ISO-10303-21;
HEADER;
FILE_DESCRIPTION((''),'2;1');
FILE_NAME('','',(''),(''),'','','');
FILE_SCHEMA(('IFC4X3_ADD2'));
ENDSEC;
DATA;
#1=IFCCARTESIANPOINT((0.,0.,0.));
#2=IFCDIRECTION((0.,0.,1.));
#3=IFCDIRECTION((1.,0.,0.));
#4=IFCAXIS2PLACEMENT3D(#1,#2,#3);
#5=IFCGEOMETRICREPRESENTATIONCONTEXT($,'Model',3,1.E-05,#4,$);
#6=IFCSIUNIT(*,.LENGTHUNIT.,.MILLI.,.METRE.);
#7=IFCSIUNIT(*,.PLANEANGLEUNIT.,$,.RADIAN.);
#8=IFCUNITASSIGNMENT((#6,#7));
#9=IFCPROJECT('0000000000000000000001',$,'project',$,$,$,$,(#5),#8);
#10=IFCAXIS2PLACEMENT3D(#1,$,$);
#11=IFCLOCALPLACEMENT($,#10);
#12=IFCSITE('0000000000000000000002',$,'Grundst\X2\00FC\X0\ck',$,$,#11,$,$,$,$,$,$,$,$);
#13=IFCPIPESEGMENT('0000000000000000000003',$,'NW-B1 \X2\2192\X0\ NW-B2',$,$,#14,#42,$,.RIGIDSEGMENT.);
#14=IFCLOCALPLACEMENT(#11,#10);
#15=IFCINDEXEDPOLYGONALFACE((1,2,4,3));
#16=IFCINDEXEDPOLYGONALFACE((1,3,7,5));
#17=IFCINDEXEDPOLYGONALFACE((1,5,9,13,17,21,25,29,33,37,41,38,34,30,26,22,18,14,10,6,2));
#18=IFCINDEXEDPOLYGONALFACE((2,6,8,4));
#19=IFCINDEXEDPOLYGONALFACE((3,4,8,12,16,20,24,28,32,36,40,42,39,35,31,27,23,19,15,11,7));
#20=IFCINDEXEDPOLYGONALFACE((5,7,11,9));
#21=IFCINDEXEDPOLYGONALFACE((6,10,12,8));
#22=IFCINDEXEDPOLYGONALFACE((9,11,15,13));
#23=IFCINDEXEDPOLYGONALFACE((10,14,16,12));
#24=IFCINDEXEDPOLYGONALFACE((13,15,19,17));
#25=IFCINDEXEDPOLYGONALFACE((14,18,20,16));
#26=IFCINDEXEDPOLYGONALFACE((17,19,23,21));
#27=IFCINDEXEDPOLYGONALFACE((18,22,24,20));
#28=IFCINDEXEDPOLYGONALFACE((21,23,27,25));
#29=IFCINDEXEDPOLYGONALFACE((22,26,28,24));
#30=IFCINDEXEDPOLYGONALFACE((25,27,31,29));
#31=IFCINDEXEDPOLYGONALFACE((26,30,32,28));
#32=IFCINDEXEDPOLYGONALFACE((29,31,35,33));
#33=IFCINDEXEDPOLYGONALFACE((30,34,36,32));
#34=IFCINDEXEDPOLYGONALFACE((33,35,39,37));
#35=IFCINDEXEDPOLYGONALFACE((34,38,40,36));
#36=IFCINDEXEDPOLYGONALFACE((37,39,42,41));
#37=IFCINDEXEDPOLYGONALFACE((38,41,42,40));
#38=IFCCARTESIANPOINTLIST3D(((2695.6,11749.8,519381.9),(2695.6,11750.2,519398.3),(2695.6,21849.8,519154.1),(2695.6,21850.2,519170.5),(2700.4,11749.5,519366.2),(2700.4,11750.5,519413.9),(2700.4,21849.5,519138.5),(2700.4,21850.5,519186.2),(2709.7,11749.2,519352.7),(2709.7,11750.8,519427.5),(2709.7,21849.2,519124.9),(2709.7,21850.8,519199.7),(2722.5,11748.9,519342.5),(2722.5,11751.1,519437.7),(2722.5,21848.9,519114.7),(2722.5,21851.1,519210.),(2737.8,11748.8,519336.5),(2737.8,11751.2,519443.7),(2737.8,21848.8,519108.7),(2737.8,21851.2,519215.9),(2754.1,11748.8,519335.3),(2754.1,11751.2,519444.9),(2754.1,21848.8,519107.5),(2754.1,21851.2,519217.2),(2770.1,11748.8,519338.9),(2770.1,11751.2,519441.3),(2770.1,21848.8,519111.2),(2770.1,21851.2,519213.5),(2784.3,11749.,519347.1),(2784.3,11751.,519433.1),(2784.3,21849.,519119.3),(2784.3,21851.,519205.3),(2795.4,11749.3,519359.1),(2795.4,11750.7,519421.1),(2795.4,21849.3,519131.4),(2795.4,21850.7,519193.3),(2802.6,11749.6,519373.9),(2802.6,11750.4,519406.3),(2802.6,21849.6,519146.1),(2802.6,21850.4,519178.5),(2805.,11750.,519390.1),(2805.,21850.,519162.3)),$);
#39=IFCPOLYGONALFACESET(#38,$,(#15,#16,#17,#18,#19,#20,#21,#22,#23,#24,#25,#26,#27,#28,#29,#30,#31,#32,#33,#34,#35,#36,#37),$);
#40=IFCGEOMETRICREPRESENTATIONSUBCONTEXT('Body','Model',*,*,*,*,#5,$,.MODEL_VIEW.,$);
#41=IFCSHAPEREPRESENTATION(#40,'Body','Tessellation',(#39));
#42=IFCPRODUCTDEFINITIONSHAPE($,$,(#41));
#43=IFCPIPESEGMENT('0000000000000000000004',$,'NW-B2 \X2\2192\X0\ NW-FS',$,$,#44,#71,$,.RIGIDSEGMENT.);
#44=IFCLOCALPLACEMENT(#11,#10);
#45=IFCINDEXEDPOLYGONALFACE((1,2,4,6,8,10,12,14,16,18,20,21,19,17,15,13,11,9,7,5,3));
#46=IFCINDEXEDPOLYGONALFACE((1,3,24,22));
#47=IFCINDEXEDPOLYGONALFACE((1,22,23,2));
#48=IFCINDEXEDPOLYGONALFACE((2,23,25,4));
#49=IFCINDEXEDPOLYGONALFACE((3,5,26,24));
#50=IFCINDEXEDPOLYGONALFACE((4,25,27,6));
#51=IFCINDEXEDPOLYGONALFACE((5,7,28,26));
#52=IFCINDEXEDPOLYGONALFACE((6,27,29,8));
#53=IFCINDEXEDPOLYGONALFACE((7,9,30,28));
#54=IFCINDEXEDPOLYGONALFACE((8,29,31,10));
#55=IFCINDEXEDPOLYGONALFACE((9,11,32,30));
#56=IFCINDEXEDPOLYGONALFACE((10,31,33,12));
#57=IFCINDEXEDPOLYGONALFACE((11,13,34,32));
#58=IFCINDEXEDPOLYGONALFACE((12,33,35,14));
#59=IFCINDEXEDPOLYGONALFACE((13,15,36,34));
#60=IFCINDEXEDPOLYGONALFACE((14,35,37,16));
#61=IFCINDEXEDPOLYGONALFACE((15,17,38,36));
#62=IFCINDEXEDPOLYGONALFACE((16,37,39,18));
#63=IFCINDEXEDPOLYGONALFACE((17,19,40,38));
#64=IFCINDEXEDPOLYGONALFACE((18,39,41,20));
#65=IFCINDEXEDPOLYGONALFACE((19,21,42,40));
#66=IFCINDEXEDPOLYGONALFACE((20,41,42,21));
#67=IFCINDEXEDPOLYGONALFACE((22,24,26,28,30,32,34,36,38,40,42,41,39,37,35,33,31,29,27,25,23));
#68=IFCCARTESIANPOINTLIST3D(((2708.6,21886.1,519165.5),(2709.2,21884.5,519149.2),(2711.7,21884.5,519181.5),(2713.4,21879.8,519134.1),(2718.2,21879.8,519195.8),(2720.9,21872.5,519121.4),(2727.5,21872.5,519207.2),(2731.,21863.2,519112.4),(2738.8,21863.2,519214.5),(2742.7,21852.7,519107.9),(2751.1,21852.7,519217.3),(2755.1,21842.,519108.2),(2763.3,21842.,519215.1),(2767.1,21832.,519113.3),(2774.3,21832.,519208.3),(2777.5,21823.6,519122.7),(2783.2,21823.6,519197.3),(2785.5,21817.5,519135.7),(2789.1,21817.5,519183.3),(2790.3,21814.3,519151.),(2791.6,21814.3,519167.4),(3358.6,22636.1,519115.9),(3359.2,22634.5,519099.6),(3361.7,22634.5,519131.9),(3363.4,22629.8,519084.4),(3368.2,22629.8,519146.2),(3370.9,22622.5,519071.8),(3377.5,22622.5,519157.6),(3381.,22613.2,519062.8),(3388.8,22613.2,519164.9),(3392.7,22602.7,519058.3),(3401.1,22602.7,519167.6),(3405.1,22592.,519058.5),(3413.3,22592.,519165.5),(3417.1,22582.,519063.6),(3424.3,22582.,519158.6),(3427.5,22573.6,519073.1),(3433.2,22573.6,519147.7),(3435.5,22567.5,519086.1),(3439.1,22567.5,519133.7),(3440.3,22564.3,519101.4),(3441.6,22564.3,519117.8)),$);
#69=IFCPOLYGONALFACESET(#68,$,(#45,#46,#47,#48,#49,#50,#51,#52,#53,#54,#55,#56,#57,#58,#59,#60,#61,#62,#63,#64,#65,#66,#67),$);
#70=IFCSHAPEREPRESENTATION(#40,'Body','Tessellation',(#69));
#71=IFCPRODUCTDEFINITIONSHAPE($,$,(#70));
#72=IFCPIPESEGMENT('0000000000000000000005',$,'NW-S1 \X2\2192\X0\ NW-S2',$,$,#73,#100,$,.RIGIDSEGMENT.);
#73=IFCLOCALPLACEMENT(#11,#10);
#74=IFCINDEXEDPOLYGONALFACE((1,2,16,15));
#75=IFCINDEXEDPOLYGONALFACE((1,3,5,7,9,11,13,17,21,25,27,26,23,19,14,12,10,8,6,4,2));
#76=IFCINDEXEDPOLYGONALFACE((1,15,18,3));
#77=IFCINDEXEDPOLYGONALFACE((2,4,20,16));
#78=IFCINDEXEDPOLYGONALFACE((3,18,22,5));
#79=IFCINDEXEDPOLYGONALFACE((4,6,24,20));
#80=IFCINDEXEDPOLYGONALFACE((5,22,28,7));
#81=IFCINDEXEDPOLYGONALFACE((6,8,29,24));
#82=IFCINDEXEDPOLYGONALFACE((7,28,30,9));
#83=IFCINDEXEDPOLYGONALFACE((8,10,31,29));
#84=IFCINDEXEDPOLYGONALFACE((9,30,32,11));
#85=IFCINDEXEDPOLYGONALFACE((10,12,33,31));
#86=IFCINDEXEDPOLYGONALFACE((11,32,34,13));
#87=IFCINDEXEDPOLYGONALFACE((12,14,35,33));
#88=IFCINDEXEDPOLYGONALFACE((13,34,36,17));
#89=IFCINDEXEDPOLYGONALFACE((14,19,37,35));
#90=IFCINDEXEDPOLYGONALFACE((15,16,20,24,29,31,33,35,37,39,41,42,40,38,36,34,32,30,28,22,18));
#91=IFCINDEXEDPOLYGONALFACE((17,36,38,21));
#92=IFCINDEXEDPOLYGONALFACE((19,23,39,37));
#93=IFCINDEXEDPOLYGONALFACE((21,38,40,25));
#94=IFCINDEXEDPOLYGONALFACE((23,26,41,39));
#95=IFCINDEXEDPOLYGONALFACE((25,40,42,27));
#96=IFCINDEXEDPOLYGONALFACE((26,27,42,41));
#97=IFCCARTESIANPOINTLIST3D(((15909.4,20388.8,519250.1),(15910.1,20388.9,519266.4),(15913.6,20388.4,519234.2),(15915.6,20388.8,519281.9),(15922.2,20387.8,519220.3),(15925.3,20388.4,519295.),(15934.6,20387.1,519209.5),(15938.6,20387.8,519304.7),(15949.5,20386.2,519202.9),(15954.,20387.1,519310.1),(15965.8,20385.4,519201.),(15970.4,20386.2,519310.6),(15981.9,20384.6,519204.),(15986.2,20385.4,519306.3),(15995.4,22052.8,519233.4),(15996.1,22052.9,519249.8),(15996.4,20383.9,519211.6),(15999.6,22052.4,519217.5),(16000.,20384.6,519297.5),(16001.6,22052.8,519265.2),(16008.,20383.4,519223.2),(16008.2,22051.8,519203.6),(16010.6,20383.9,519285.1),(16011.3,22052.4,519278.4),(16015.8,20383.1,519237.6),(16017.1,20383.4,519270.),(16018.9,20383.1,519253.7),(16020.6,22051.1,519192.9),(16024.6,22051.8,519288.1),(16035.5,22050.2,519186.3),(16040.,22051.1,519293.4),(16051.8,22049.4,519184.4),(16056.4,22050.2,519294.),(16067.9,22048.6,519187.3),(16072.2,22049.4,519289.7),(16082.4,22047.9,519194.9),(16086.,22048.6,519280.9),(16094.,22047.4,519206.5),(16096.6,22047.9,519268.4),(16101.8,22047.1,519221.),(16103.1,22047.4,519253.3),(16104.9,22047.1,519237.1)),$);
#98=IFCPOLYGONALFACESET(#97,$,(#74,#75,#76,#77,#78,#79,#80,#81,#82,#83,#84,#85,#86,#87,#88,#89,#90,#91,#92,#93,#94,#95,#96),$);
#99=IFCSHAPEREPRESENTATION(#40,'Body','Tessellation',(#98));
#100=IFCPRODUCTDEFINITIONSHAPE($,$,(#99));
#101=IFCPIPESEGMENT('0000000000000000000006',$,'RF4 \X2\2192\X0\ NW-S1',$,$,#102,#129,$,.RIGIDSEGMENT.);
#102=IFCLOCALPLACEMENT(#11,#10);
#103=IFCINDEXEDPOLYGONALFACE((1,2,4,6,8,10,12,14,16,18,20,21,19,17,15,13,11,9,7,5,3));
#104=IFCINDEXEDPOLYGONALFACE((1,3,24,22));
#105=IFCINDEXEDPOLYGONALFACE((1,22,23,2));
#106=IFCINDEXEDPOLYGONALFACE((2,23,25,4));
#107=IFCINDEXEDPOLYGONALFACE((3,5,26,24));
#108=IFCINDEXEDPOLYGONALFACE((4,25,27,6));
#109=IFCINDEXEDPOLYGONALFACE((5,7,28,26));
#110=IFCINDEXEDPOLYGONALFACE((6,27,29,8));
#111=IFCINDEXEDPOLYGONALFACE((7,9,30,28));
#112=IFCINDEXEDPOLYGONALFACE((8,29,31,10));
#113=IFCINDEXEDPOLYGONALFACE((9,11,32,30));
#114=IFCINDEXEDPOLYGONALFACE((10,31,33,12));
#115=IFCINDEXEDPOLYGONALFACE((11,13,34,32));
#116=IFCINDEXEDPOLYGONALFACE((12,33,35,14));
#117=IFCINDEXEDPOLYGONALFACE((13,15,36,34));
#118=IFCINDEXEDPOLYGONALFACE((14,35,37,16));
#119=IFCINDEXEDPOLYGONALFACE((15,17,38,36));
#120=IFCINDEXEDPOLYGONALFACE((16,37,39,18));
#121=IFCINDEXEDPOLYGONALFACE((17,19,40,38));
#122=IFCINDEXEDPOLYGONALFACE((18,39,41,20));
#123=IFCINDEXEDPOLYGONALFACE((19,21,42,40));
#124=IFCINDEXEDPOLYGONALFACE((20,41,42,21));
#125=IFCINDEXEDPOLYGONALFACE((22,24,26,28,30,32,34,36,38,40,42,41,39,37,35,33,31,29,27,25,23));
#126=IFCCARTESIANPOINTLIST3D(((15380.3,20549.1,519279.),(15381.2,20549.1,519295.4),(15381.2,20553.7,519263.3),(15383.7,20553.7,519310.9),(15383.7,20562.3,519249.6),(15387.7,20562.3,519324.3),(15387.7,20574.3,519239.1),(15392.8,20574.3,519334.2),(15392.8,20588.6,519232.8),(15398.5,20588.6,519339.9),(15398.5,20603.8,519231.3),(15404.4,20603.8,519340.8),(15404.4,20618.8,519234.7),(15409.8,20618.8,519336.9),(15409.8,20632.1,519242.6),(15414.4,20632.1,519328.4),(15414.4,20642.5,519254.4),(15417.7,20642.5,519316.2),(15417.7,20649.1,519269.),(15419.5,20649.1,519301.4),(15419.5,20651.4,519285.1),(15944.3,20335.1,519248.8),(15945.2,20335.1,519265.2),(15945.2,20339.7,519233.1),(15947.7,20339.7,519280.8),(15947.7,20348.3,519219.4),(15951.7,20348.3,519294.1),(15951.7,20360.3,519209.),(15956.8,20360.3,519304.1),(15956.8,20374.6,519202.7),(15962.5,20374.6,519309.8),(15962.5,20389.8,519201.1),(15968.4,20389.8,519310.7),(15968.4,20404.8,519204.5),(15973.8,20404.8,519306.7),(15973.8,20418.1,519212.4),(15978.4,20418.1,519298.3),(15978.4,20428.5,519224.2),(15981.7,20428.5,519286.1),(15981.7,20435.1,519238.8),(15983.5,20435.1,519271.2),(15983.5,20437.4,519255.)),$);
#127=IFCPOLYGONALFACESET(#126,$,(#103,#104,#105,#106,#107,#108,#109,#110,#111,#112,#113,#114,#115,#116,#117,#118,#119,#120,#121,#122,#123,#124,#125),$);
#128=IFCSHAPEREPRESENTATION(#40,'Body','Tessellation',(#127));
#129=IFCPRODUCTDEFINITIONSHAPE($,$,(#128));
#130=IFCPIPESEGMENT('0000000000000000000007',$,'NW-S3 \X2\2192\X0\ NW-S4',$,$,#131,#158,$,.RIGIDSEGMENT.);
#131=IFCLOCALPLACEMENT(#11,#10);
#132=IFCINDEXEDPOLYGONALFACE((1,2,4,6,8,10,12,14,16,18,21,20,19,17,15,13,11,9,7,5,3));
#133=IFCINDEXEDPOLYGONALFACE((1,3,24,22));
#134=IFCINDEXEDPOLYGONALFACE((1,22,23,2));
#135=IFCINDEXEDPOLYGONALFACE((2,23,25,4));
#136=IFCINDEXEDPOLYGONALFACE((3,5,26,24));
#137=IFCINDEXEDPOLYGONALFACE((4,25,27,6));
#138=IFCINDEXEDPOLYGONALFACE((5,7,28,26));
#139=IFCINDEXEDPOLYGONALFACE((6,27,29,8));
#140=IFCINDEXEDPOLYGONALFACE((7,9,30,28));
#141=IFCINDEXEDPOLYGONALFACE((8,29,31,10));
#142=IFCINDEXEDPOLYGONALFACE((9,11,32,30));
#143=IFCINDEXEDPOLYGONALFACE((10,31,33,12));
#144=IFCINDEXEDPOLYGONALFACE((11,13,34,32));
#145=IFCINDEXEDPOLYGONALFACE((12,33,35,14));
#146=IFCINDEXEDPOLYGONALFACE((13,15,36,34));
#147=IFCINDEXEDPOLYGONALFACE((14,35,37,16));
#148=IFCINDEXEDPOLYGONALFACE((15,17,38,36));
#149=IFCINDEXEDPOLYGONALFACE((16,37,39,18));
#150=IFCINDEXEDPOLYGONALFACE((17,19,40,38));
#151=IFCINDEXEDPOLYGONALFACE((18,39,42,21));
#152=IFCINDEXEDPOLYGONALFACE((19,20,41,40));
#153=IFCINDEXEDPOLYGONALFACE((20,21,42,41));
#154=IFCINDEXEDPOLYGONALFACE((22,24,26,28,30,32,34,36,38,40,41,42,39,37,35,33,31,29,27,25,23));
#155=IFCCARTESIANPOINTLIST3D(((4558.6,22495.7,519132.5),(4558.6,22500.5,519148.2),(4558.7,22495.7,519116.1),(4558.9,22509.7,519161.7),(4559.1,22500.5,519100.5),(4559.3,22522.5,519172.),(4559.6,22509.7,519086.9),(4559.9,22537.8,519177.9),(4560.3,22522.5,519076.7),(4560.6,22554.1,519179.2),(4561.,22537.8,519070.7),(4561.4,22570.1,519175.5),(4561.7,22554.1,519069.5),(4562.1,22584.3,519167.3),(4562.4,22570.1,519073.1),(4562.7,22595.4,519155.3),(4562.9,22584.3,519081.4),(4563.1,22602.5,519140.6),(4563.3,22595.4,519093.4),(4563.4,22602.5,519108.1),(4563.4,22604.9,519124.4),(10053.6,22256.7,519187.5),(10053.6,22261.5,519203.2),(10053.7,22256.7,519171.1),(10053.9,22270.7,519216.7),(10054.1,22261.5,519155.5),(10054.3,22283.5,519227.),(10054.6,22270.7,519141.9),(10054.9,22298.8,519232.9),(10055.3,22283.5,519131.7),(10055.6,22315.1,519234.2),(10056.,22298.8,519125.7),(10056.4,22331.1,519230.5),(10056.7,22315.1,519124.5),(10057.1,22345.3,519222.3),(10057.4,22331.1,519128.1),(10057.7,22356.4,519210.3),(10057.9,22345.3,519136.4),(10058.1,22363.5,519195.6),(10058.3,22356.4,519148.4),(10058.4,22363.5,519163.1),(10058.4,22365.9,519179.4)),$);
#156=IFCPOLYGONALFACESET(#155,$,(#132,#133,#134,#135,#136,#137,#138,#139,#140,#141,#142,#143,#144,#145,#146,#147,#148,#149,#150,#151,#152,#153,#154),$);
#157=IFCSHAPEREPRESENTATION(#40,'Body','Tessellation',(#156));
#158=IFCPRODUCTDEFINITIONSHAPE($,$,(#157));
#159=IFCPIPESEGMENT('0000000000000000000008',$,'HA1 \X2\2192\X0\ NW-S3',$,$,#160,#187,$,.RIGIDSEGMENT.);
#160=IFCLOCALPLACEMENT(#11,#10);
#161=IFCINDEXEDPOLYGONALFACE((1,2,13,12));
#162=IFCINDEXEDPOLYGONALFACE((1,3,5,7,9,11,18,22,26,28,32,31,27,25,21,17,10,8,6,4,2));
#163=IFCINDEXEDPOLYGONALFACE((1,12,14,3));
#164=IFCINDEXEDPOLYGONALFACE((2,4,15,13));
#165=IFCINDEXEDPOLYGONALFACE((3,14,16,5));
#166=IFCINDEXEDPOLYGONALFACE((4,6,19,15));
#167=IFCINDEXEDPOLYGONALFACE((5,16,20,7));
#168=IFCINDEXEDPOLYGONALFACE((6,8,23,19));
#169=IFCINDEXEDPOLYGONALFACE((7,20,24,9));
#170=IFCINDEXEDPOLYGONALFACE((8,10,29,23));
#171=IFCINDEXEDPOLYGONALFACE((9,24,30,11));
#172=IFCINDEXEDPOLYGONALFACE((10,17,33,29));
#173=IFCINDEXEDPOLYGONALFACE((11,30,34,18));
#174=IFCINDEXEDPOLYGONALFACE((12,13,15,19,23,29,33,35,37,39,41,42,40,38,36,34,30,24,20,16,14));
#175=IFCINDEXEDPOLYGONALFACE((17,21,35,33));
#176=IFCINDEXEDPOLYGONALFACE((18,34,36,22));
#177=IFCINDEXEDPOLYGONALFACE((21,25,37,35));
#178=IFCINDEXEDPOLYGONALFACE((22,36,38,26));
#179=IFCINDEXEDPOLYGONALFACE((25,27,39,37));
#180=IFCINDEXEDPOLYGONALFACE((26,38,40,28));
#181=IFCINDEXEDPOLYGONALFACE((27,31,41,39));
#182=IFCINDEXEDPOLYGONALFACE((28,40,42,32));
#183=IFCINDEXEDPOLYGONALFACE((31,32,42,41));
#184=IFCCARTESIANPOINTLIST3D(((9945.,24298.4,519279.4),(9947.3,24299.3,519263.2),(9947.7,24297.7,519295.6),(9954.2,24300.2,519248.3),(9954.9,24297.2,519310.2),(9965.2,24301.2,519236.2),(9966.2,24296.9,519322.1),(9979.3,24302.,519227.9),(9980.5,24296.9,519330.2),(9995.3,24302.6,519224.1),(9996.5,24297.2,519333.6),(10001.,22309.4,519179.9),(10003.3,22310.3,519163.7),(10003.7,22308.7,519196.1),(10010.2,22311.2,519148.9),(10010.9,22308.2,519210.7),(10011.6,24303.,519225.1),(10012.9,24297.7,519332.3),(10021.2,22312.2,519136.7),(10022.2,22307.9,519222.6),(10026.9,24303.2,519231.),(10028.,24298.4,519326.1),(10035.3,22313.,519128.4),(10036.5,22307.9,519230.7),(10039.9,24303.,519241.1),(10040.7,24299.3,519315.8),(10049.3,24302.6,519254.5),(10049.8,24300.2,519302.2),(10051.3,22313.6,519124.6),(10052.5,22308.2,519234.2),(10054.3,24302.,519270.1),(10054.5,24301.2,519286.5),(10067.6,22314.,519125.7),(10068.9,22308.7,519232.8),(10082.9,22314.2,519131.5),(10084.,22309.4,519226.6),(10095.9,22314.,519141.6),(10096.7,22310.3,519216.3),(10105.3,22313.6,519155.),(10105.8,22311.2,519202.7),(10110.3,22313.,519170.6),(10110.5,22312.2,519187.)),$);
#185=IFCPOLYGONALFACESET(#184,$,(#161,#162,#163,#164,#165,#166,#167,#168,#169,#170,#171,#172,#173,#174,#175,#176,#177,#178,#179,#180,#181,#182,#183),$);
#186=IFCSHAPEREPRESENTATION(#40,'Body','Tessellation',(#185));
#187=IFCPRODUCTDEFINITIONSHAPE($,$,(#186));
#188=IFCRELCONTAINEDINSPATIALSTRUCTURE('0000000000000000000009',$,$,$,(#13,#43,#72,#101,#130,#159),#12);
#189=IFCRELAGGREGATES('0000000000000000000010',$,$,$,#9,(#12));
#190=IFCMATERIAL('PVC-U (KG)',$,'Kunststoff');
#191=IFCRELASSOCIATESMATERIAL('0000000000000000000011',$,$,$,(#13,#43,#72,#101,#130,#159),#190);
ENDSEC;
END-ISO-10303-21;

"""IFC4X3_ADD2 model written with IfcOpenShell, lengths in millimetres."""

from ifc_helpers import new_model, si_unit, frame, origin, origin_with_axes, place, context, subcontext, project, spatial, circle, extrude, material, element, save


model = new_model("IFC4X3_ADD2")

# Units and contexts
model_context = context("Model", 3, precision=1e-05, world=origin_with_axes())
body_context = subcontext(model_context, "Body", "Model", "MODEL_VIEW")
ifc_project = project(units=[si_unit("LENGTHUNIT", "METRE", prefix="MILLI"), si_unit("PLANEANGLEUNIT", "RADIAN")], contexts=[model_context])

# Site
site_placement = place(None, origin())
site = spatial("IfcSite", under=ifc_project, at=site_placement, Name="Grundstück")

# Shared definitions
ifc_material = material(Name="PVC-U (KG)", Category="Kunststoff")

# Pipe segments
pipe_segment_1_placement = place(site_placement, frame((2750.0, 11750.0, 519335.1)))
element("IfcPipeSegment", 1, at=pipe_segment_1_placement, inside=site, material=ifc_material, Name="NW-B1 → NW-B2", PredefinedType="RIGIDSEGMENT", context=body_context, shape_type="SweptSolid", body=[
    extrude(circle(Radius=55.0), frame((0.0, 0.0, 55.0), z_axis=(0.0, 0.999746, -0.022544), x_axis=(1.0, 0.0, 0.0)), (0.0, 0.0, 1.0), 10102.6),
])
pipe_segment_2_placement = place(site_placement, frame((2750.0, 21850.0, 519107.3)))
element("IfcPipeSegment", 2, at=pipe_segment_2_placement, inside=site, material=ifc_material, Name="NW-B2 → NW-FS", PredefinedType="RIGIDSEGMENT", context=body_context, shape_type="SweptSolid", body=[
    extrude(circle(Radius=55.0), frame((0.0, 0.0, 55.0), z_axis=(0.654113, 0.754746, -0.049938), x_axis=(0.0, 1.0, 0.0)), (0.0, 0.0, 1.0), 993.7),
])
pipe_segment_3_placement = place(site_placement, frame((15964.0, 20386.0, 519201.0)))
element("IfcPipeSegment", 3, at=pipe_segment_3_placement, inside=site, material=ifc_material, Name="NW-S1 → NW-S2", PredefinedType="RIGIDSEGMENT", context=body_context, shape_type="SweptSolid", body=[
    extrude(circle(Radius=55.0), frame((0.0, 0.0, 55.0), z_axis=(0.051611, 0.998617, -0.01), x_axis=(0.0, 1.0, 0.0)), (0.0, 0.0, 1.0), 1666.3),
])
pipe_segment_4_placement = place(site_placement, frame((15400.0, 20600.0, 519231.2)))
element("IfcPipeSegment", 4, at=pipe_segment_4_placement, inside=site, material=ifc_material, Name="RF4 → NW-S1", PredefinedType="RIGIDSEGMENT", context=body_context, shape_type="SweptSolid", body=[
    extrude(circle(Radius=55.0), frame((0.0, 0.0, 55.0), z_axis=(0.933793, -0.354312, -0.049938), x_axis=(0.0, 1.0, 0.0)), (0.0, 0.0, 1.0), 604.0),
])
pipe_segment_5_placement = place(site_placement, frame((10056.0, 22311.0, 519124.3)))
element("IfcPipeSegment", 5, at=pipe_segment_5_placement, inside=site, material=ifc_material, Name="NW-S3 → NW-S4", PredefinedType="RIGIDSEGMENT", context=body_context, shape_type="SweptSolid", body=[
    extrude(circle(Radius=55.0), frame((0.0, 0.0, 55.0), z_axis=(-0.999006, 0.043451, -0.01), x_axis=(0.0, 1.0, 0.0)), (0.0, 0.0, 1.0), 5500.5),
])
pipe_segment_6_placement = place(site_placement, frame((10000.0, 24300.0, 519223.8)))
element("IfcPipeSegment", 6, at=pipe_segment_6_placement, inside=site, material=ifc_material, Name="HA1 → NW-S3", PredefinedType="RIGIDSEGMENT", context=body_context, shape_type="SweptSolid", body=[
    extrude(circle(Radius=55.0), frame((0.0, 0.0, 55.0), z_axis=(0.028109, -0.998357, -0.049938), x_axis=(0.0, 1.0, 0.0)), (0.0, 0.0, 1.0), 1992.3),
])

save(model, "model.ifc")
